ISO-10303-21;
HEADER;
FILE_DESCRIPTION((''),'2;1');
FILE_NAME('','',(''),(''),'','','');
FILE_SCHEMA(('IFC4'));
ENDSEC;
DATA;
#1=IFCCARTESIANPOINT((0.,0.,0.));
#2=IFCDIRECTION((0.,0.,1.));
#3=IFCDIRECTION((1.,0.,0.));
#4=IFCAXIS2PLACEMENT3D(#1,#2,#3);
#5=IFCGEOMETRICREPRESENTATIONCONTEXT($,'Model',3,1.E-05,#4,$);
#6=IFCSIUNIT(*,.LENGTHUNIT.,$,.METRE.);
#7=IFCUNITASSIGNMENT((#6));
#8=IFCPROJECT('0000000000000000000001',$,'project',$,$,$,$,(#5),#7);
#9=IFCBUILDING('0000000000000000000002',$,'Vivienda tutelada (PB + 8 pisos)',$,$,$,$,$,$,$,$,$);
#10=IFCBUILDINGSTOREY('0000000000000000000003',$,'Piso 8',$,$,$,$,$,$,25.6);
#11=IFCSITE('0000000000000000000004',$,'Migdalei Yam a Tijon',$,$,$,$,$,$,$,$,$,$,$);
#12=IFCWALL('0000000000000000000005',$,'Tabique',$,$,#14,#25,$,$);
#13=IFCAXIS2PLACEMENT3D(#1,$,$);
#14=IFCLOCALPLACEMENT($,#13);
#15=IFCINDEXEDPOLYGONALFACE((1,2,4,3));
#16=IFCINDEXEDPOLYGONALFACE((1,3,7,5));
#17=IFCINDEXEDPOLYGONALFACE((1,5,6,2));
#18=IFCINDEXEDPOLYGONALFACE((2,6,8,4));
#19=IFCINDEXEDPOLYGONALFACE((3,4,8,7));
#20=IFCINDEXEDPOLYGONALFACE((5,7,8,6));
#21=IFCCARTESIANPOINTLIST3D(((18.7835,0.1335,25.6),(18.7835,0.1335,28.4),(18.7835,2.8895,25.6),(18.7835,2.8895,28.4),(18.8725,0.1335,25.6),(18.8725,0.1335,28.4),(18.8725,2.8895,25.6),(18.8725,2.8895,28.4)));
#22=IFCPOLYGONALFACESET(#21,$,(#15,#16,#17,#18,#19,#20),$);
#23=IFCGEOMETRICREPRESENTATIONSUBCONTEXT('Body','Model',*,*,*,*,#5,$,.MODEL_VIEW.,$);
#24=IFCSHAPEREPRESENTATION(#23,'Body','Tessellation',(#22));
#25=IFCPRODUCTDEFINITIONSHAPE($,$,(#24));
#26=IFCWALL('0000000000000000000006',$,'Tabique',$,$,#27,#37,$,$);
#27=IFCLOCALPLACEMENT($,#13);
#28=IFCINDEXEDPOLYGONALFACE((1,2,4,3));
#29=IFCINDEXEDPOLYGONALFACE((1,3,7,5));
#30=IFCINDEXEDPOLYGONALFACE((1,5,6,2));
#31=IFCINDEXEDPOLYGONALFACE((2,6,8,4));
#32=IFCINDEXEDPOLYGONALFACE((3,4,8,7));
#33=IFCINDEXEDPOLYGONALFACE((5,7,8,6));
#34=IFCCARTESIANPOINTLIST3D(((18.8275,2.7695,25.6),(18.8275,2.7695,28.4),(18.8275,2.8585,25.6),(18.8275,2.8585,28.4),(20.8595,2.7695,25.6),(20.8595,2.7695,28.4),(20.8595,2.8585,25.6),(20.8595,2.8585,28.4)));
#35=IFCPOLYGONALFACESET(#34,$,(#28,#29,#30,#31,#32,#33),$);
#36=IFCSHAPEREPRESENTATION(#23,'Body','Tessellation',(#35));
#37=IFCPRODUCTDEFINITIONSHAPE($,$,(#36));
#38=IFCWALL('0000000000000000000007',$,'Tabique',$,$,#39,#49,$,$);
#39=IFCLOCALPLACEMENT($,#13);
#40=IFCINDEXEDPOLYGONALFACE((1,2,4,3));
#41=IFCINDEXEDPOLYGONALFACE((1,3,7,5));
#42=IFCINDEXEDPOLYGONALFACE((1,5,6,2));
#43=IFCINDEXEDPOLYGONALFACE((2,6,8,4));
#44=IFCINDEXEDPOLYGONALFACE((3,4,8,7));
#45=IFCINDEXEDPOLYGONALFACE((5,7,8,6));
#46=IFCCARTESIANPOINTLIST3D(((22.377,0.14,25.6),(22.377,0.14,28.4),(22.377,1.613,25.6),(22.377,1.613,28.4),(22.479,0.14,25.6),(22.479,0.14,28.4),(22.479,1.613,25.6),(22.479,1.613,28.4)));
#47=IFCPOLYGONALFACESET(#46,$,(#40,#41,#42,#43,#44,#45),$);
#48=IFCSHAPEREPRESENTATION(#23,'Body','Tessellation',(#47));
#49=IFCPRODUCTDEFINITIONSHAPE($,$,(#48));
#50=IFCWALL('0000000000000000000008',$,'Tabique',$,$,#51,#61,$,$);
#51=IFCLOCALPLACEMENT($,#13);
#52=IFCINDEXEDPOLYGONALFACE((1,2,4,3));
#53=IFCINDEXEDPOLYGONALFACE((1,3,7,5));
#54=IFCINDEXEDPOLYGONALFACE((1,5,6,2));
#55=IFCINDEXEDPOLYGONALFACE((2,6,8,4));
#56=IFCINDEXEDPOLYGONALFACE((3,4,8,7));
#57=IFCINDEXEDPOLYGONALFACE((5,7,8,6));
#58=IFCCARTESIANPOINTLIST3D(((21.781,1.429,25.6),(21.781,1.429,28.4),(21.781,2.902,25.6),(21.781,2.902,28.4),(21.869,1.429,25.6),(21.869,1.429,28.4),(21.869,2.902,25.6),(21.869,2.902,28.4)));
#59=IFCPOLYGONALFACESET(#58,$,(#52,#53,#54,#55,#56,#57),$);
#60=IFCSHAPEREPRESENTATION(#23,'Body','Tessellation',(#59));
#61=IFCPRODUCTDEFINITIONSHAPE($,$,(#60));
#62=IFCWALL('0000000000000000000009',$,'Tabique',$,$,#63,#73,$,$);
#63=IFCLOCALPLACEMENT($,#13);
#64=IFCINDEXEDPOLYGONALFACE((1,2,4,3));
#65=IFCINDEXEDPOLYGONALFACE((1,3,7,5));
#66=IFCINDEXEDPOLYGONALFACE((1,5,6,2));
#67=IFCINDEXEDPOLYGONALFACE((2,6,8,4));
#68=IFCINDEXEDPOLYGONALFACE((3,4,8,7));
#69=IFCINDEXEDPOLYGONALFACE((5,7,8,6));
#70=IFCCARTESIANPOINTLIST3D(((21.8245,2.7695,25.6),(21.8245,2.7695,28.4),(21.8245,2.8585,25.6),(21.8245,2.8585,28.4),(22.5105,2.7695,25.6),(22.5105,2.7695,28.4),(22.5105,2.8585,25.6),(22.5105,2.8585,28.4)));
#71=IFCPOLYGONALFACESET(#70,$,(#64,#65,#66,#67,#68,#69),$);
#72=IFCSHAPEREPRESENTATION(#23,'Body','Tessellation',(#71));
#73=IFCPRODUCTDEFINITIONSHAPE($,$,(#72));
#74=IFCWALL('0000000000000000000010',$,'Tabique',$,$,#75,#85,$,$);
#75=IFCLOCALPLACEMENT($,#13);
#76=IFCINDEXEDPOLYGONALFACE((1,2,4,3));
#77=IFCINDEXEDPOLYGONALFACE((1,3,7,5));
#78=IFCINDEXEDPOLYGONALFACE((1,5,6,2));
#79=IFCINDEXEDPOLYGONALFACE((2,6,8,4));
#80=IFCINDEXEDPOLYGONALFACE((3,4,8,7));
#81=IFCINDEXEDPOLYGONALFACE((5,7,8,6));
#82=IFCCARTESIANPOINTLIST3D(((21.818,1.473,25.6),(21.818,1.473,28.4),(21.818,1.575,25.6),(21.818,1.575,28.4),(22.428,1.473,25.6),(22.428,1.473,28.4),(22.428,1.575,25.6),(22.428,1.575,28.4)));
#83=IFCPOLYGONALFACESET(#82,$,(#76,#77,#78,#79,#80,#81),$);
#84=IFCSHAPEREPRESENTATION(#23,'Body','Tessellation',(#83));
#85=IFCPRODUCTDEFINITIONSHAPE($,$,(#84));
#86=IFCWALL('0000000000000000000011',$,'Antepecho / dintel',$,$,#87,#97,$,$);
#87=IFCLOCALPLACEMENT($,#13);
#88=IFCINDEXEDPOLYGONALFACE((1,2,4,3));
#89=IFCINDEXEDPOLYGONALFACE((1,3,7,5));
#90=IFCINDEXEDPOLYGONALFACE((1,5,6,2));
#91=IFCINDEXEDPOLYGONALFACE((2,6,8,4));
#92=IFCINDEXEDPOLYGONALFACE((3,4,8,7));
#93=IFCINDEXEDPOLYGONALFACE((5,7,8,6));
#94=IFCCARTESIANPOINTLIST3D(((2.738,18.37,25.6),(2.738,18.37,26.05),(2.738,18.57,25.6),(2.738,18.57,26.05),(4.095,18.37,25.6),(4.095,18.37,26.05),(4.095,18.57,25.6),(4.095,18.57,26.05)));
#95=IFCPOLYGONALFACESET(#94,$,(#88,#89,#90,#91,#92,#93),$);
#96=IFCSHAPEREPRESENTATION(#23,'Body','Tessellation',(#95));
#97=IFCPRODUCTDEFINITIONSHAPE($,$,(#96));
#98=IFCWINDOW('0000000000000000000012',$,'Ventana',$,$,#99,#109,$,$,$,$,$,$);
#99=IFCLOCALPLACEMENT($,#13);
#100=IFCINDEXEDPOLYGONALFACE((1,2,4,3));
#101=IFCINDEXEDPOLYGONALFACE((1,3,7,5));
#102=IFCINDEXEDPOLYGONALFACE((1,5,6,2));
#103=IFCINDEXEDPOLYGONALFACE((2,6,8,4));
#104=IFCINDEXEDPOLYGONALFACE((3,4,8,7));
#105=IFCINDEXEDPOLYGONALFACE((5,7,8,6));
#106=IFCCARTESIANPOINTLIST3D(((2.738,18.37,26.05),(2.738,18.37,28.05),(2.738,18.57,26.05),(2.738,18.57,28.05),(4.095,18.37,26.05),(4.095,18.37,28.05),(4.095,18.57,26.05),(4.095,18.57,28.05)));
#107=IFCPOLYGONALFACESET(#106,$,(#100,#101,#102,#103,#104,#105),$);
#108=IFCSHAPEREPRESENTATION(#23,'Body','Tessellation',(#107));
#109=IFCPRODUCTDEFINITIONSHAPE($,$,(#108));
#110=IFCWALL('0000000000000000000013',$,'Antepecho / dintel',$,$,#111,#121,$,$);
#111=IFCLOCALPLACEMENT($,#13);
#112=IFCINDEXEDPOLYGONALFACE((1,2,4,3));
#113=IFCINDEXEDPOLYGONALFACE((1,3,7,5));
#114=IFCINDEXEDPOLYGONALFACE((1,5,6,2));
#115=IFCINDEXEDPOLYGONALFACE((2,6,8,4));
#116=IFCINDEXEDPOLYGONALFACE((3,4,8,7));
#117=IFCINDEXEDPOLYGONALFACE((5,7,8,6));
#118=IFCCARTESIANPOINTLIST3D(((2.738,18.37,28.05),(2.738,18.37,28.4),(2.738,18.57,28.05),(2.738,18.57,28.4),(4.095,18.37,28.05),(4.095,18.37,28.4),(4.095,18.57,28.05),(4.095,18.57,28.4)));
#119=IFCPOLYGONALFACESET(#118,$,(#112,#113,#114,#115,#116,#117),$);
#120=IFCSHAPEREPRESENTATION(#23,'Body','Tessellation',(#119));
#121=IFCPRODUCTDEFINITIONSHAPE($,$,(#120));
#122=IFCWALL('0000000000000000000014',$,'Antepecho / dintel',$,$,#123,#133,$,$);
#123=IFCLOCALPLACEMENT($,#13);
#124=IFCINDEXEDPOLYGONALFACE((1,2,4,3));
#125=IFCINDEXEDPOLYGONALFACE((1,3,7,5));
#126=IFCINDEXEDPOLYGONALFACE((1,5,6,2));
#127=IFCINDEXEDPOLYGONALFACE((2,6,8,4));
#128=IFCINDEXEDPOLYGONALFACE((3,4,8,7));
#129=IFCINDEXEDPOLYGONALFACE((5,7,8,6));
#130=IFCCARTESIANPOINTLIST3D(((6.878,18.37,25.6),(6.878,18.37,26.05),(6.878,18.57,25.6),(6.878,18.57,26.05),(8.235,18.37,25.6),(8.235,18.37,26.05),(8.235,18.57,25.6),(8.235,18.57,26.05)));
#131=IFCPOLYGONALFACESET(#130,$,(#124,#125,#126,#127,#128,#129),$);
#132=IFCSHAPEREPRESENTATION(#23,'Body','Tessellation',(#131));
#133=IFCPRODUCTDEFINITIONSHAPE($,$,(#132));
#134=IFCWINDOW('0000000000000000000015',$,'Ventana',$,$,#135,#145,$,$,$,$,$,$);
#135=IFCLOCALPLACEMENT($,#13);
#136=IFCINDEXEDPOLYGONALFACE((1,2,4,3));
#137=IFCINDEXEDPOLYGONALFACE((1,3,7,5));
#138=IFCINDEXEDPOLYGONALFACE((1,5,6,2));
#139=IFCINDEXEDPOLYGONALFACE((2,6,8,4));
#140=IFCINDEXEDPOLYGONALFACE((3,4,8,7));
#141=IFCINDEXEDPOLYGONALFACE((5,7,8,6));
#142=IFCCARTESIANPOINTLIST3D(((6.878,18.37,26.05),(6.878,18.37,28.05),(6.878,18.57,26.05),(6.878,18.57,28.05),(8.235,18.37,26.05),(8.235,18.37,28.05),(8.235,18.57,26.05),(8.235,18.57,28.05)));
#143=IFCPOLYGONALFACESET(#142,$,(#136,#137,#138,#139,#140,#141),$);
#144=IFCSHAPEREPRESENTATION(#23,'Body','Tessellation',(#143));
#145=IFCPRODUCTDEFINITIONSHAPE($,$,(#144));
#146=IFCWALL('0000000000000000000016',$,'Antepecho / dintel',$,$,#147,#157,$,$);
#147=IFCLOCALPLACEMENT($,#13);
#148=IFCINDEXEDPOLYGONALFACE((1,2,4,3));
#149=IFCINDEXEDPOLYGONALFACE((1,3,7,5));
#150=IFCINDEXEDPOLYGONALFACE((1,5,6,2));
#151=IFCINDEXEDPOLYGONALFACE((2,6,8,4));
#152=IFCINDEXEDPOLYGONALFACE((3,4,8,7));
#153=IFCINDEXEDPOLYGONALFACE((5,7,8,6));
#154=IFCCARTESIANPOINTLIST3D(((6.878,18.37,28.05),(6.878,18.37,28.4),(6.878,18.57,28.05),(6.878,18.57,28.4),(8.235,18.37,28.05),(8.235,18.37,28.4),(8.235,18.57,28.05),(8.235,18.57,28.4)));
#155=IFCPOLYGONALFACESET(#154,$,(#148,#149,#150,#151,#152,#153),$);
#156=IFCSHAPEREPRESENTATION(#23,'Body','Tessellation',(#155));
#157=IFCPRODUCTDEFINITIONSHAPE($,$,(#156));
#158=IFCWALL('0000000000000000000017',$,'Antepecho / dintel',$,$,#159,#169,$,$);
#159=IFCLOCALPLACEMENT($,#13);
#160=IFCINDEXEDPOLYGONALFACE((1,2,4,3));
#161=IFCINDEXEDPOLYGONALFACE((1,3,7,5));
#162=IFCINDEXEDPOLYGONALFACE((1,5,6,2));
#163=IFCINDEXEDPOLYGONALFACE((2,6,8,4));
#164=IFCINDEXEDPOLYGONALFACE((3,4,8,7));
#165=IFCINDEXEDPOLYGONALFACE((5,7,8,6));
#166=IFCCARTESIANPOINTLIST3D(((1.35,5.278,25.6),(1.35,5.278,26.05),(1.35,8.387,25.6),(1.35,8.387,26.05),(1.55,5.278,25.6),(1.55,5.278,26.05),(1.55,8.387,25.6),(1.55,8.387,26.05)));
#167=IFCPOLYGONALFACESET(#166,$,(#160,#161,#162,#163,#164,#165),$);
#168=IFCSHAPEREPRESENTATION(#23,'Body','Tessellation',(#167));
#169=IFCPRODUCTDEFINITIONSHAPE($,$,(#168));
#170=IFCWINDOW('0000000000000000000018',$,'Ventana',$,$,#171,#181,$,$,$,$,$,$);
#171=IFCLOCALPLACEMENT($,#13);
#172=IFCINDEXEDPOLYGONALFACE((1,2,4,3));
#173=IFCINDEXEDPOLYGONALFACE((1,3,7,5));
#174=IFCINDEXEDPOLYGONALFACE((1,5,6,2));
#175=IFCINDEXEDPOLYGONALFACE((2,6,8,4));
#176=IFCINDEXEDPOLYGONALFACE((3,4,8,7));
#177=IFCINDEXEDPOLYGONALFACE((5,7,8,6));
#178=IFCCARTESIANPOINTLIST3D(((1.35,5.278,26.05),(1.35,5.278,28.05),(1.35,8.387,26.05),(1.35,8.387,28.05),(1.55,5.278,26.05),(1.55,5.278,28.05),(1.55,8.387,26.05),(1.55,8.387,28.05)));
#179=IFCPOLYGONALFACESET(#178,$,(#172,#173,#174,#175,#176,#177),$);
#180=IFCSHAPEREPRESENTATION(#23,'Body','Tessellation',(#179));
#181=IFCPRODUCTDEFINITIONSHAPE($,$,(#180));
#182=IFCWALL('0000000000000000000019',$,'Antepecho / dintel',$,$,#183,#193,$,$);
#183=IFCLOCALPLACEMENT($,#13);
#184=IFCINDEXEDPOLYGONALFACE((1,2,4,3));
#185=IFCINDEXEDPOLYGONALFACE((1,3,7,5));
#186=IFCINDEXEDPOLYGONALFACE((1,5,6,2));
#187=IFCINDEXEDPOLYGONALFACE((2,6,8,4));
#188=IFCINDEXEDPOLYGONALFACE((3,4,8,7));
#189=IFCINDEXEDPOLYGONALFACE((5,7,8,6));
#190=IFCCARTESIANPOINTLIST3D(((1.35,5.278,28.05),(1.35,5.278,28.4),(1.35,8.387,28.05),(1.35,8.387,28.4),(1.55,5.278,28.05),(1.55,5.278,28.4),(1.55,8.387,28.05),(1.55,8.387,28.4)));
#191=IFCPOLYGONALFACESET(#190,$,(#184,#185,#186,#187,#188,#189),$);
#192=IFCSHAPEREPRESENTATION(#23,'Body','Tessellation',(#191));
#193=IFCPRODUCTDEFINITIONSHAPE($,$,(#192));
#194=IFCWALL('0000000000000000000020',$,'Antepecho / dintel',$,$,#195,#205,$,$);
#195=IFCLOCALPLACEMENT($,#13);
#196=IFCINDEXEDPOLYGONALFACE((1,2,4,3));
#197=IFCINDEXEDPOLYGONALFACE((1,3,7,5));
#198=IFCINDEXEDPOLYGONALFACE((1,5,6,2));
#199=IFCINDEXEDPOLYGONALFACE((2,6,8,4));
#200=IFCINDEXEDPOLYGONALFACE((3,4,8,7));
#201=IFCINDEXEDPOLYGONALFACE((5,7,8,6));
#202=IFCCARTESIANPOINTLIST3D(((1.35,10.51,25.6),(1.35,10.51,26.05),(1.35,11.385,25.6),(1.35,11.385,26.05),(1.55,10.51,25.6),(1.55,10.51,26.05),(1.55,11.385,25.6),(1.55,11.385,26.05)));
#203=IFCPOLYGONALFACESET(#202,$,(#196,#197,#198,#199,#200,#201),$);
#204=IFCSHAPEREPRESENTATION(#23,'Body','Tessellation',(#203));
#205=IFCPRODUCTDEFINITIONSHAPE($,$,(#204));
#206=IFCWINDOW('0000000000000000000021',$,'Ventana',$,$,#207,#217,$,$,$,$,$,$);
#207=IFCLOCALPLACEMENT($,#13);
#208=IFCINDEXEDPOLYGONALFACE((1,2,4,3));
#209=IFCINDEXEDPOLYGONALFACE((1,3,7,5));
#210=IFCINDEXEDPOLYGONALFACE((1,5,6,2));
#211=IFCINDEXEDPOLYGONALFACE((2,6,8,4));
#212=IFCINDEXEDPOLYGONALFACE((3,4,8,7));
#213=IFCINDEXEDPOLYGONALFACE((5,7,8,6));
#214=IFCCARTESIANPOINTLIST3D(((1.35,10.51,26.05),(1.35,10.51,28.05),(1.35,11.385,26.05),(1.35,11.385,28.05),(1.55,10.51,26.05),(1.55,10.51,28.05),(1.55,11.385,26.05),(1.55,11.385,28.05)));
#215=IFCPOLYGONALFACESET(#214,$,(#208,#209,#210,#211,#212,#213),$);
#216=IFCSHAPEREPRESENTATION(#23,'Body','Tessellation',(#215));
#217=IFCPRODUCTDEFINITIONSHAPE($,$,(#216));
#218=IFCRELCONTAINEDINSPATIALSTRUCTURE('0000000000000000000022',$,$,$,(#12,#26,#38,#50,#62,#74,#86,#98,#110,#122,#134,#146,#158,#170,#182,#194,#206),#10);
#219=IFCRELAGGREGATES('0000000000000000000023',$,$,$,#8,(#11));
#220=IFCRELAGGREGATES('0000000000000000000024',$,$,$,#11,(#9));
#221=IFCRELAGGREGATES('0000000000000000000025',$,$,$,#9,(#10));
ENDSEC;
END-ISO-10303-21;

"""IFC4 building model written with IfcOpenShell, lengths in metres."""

from ifc_helpers import new_model, si_unit, frame, origin_with_axes, context, subcontext, project, spatial, line, indexed_curve, outline, extrude, element, save


model = new_model("IFC4")

# Units and contexts
model_context = context("Model", 3, precision=1e-05, world=origin_with_axes())
body_context = subcontext(model_context, "Body", "Model", "MODEL_VIEW")
ifc_project = project(units=[si_unit("LENGTHUNIT", "METRE")], contexts=[model_context])

# Site, building, storey
site = spatial("IfcSite", under=ifc_project, Name="Migdalei Yam a Tijon")
building = spatial("IfcBuilding", under=site, Name="Vivienda tutelada (PB + 8 pisos)")
storey = spatial("IfcBuildingStorey", under=building, Name="Piso 8", Elevation=25.6)

# Walls
element("IfcWall", 1, inside=storey, Name="Tabique", context=body_context, shape_type="SweptSolid", body=[
    extrude(outline(indexed_curve([(0.0, 0.0), (0.089, 0.0), (0.089, 2.756), (0.0, 2.756)], segments=[line(1, 2, 3, 4, 1)])), frame((18.7835, 0.1335, 25.6), z_axis=(0.0, 0.0, 1.0), x_axis=(1.0, 0.0, 0.0)), (0.0, 0.0, 1.0), 2.8),
])
element("IfcWall", 2, inside=storey, Name="Tabique", context=body_context, shape_type="SweptSolid", body=[
    extrude(outline(indexed_curve([(0.0, 0.0), (2.032, 0.0), (2.032, 0.089), (0.0, 0.089)], segments=[line(1, 2, 3, 4, 1)])), frame((18.8275, 2.7695, 25.6), z_axis=(0.0, 0.0, 1.0), x_axis=(1.0, 0.0, 0.0)), (0.0, 0.0, 1.0), 2.8),
])
element("IfcWall", 3, inside=storey, Name="Tabique", context=body_context, shape_type="SweptSolid", body=[
    extrude(outline(indexed_curve([(0.0, 0.0), (0.102, 0.0), (0.102, 1.473), (0.0, 1.473)], segments=[line(1, 2, 3, 4, 1)])), frame((22.377, 0.14, 25.6), z_axis=(0.0, 0.0, 1.0), x_axis=(1.0, 0.0, 0.0)), (0.0, 0.0, 1.0), 2.8),
])
element("IfcWall", 4, inside=storey, Name="Tabique", context=body_context, shape_type="SweptSolid", body=[
    extrude(outline(indexed_curve([(0.0, 0.0), (0.088, 0.0), (0.088, 1.473), (0.0, 1.473)], segments=[line(1, 2, 3, 4, 1)])), frame((21.781, 1.429, 25.6), z_axis=(0.0, 0.0, 1.0), x_axis=(1.0, 0.0, 0.0)), (0.0, 0.0, 1.0), 2.8),
])
element("IfcWall", 5, inside=storey, Name="Tabique", context=body_context, shape_type="SweptSolid", body=[
    extrude(outline(indexed_curve([(0.0, 0.0), (0.686, 0.0), (0.686, 0.089), (0.0, 0.089)], segments=[line(1, 2, 3, 4, 1)])), frame((21.8245, 2.7695, 25.6), z_axis=(0.0, 0.0, 1.0), x_axis=(1.0, 0.0, 0.0)), (0.0, 0.0, 1.0), 2.8),
])
element("IfcWall", 6, inside=storey, Name="Tabique", context=body_context, shape_type="SweptSolid", body=[
    extrude(outline(indexed_curve([(0.0, 0.0), (0.61, 0.0), (0.61, 0.102), (0.0, 0.102)], segments=[line(1, 2, 3, 4, 1)])), frame((21.818, 1.473, 25.6), z_axis=(0.0, 0.0, 1.0), x_axis=(1.0, 0.0, 0.0)), (0.0, 0.0, 1.0), 2.8),
])
element("IfcWall", 7, inside=storey, Name="Antepecho / dintel", context=body_context, shape_type="SweptSolid", body=[
    extrude(outline(indexed_curve([(0.0, 0.0), (1.357, 0.0), (1.357, 0.2), (0.0, 0.2)], segments=[line(1, 2, 3, 4, 1)])), frame((2.738, 18.37, 25.6), z_axis=(0.0, 0.0, 1.0), x_axis=(1.0, 0.0, 0.0)), (0.0, 0.0, 1.0), 0.45),
])

# Window
element("IfcWindow", 8, inside=storey, Name="Ventana", context=body_context, shape_type="SweptSolid", body=[
    extrude(outline(indexed_curve([(0.0, 0.0), (1.357, 0.0), (1.357, 0.2), (0.0, 0.2)], segments=[line(1, 2, 3, 4, 1)])), frame((2.738, 18.37, 26.05), z_axis=(0.0, 0.0, 1.0), x_axis=(1.0, 0.0, 0.0)), (0.0, 0.0, 1.0), 2.0),
])

# Walls
element("IfcWall", 9, inside=storey, Name="Antepecho / dintel", context=body_context, shape_type="SweptSolid", body=[
    extrude(outline(indexed_curve([(0.0, 0.0), (1.357, 0.0), (1.357, 0.2), (0.0, 0.2)], segments=[line(1, 2, 3, 4, 1)])), frame((2.738, 18.37, 28.05), z_axis=(0.0, 0.0, 1.0), x_axis=(1.0, 0.0, 0.0)), (0.0, 0.0, 1.0), 0.35),
])
element("IfcWall", 10, inside=storey, Name="Antepecho / dintel", context=body_context, shape_type="SweptSolid", body=[
    extrude(outline(indexed_curve([(0.0, 0.0), (1.357, 0.0), (1.357, 0.2), (0.0, 0.2)], segments=[line(1, 2, 3, 4, 1)])), frame((6.878, 18.37, 25.6), z_axis=(0.0, 0.0, 1.0), x_axis=(1.0, 0.0, 0.0)), (0.0, 0.0, 1.0), 0.45),
])

# Window
element("IfcWindow", 11, inside=storey, Name="Ventana", context=body_context, shape_type="SweptSolid", body=[
    extrude(outline(indexed_curve([(0.0, 0.0), (1.357, 0.0), (1.357, 0.2), (0.0, 0.2)], segments=[line(1, 2, 3, 4, 1)])), frame((6.878, 18.37, 26.05), z_axis=(0.0, 0.0, 1.0), x_axis=(1.0, 0.0, 0.0)), (0.0, 0.0, 1.0), 2.0),
])

# Walls
element("IfcWall", 12, inside=storey, Name="Antepecho / dintel", context=body_context, shape_type="SweptSolid", body=[
    extrude(outline(indexed_curve([(0.0, 0.0), (1.357, 0.0), (1.357, 0.2), (0.0, 0.2)], segments=[line(1, 2, 3, 4, 1)])), frame((6.878, 18.37, 28.05), z_axis=(0.0, 0.0, 1.0), x_axis=(1.0, 0.0, 0.0)), (0.0, 0.0, 1.0), 0.35),
])
element("IfcWall", 13, inside=storey, Name="Antepecho / dintel", context=body_context, shape_type="SweptSolid", body=[
    extrude(outline(indexed_curve([(0.0, 0.0), (0.2, 0.0), (0.2, 3.109), (0.0, 3.109)], segments=[line(1, 2, 3, 4, 1)])), frame((1.35, 5.278, 25.6), z_axis=(0.0, 0.0, 1.0), x_axis=(1.0, 0.0, 0.0)), (0.0, 0.0, 1.0), 0.45),
])

# Window
element("IfcWindow", 14, inside=storey, Name="Ventana", context=body_context, shape_type="SweptSolid", body=[
    extrude(outline(indexed_curve([(0.0, 0.0), (0.2, 0.0), (0.2, 3.109), (0.0, 3.109)], segments=[line(1, 2, 3, 4, 1)])), frame((1.35, 5.278, 26.05), z_axis=(0.0, 0.0, 1.0), x_axis=(1.0, 0.0, 0.0)), (0.0, 0.0, 1.0), 2.0),
])

# Walls
element("IfcWall", 15, inside=storey, Name="Antepecho / dintel", context=body_context, shape_type="SweptSolid", body=[
    extrude(outline(indexed_curve([(0.0, 0.0), (0.2, 0.0), (0.2, 3.109), (0.0, 3.109)], segments=[line(1, 2, 3, 4, 1)])), frame((1.35, 5.278, 28.05), z_axis=(0.0, 0.0, 1.0), x_axis=(1.0, 0.0, 0.0)), (0.0, 0.0, 1.0), 0.35),
])
element("IfcWall", 16, inside=storey, Name="Antepecho / dintel", context=body_context, shape_type="SweptSolid", body=[
    extrude(outline(indexed_curve([(0.0, 0.0), (0.2, 0.0), (0.2, 0.875), (0.0, 0.875)], segments=[line(1, 2, 3, 4, 1)])), frame((1.35, 10.51, 25.6), z_axis=(0.0, 0.0, 1.0), x_axis=(1.0, 0.0, 0.0)), (0.0, 0.0, 1.0), 0.45),
])

# Window
element("IfcWindow", 17, inside=storey, Name="Ventana", context=body_context, shape_type="SweptSolid", body=[
    extrude(outline(indexed_curve([(0.0, 0.0), (0.2, 0.0), (0.2, 0.875), (0.0, 0.875)], segments=[line(1, 2, 3, 4, 1)])), frame((1.35, 10.51, 26.05), z_axis=(0.0, 0.0, 1.0), x_axis=(1.0, 0.0, 0.0)), (0.0, 0.0, 1.0), 2.0),
])

save(model, "model.ifc")
